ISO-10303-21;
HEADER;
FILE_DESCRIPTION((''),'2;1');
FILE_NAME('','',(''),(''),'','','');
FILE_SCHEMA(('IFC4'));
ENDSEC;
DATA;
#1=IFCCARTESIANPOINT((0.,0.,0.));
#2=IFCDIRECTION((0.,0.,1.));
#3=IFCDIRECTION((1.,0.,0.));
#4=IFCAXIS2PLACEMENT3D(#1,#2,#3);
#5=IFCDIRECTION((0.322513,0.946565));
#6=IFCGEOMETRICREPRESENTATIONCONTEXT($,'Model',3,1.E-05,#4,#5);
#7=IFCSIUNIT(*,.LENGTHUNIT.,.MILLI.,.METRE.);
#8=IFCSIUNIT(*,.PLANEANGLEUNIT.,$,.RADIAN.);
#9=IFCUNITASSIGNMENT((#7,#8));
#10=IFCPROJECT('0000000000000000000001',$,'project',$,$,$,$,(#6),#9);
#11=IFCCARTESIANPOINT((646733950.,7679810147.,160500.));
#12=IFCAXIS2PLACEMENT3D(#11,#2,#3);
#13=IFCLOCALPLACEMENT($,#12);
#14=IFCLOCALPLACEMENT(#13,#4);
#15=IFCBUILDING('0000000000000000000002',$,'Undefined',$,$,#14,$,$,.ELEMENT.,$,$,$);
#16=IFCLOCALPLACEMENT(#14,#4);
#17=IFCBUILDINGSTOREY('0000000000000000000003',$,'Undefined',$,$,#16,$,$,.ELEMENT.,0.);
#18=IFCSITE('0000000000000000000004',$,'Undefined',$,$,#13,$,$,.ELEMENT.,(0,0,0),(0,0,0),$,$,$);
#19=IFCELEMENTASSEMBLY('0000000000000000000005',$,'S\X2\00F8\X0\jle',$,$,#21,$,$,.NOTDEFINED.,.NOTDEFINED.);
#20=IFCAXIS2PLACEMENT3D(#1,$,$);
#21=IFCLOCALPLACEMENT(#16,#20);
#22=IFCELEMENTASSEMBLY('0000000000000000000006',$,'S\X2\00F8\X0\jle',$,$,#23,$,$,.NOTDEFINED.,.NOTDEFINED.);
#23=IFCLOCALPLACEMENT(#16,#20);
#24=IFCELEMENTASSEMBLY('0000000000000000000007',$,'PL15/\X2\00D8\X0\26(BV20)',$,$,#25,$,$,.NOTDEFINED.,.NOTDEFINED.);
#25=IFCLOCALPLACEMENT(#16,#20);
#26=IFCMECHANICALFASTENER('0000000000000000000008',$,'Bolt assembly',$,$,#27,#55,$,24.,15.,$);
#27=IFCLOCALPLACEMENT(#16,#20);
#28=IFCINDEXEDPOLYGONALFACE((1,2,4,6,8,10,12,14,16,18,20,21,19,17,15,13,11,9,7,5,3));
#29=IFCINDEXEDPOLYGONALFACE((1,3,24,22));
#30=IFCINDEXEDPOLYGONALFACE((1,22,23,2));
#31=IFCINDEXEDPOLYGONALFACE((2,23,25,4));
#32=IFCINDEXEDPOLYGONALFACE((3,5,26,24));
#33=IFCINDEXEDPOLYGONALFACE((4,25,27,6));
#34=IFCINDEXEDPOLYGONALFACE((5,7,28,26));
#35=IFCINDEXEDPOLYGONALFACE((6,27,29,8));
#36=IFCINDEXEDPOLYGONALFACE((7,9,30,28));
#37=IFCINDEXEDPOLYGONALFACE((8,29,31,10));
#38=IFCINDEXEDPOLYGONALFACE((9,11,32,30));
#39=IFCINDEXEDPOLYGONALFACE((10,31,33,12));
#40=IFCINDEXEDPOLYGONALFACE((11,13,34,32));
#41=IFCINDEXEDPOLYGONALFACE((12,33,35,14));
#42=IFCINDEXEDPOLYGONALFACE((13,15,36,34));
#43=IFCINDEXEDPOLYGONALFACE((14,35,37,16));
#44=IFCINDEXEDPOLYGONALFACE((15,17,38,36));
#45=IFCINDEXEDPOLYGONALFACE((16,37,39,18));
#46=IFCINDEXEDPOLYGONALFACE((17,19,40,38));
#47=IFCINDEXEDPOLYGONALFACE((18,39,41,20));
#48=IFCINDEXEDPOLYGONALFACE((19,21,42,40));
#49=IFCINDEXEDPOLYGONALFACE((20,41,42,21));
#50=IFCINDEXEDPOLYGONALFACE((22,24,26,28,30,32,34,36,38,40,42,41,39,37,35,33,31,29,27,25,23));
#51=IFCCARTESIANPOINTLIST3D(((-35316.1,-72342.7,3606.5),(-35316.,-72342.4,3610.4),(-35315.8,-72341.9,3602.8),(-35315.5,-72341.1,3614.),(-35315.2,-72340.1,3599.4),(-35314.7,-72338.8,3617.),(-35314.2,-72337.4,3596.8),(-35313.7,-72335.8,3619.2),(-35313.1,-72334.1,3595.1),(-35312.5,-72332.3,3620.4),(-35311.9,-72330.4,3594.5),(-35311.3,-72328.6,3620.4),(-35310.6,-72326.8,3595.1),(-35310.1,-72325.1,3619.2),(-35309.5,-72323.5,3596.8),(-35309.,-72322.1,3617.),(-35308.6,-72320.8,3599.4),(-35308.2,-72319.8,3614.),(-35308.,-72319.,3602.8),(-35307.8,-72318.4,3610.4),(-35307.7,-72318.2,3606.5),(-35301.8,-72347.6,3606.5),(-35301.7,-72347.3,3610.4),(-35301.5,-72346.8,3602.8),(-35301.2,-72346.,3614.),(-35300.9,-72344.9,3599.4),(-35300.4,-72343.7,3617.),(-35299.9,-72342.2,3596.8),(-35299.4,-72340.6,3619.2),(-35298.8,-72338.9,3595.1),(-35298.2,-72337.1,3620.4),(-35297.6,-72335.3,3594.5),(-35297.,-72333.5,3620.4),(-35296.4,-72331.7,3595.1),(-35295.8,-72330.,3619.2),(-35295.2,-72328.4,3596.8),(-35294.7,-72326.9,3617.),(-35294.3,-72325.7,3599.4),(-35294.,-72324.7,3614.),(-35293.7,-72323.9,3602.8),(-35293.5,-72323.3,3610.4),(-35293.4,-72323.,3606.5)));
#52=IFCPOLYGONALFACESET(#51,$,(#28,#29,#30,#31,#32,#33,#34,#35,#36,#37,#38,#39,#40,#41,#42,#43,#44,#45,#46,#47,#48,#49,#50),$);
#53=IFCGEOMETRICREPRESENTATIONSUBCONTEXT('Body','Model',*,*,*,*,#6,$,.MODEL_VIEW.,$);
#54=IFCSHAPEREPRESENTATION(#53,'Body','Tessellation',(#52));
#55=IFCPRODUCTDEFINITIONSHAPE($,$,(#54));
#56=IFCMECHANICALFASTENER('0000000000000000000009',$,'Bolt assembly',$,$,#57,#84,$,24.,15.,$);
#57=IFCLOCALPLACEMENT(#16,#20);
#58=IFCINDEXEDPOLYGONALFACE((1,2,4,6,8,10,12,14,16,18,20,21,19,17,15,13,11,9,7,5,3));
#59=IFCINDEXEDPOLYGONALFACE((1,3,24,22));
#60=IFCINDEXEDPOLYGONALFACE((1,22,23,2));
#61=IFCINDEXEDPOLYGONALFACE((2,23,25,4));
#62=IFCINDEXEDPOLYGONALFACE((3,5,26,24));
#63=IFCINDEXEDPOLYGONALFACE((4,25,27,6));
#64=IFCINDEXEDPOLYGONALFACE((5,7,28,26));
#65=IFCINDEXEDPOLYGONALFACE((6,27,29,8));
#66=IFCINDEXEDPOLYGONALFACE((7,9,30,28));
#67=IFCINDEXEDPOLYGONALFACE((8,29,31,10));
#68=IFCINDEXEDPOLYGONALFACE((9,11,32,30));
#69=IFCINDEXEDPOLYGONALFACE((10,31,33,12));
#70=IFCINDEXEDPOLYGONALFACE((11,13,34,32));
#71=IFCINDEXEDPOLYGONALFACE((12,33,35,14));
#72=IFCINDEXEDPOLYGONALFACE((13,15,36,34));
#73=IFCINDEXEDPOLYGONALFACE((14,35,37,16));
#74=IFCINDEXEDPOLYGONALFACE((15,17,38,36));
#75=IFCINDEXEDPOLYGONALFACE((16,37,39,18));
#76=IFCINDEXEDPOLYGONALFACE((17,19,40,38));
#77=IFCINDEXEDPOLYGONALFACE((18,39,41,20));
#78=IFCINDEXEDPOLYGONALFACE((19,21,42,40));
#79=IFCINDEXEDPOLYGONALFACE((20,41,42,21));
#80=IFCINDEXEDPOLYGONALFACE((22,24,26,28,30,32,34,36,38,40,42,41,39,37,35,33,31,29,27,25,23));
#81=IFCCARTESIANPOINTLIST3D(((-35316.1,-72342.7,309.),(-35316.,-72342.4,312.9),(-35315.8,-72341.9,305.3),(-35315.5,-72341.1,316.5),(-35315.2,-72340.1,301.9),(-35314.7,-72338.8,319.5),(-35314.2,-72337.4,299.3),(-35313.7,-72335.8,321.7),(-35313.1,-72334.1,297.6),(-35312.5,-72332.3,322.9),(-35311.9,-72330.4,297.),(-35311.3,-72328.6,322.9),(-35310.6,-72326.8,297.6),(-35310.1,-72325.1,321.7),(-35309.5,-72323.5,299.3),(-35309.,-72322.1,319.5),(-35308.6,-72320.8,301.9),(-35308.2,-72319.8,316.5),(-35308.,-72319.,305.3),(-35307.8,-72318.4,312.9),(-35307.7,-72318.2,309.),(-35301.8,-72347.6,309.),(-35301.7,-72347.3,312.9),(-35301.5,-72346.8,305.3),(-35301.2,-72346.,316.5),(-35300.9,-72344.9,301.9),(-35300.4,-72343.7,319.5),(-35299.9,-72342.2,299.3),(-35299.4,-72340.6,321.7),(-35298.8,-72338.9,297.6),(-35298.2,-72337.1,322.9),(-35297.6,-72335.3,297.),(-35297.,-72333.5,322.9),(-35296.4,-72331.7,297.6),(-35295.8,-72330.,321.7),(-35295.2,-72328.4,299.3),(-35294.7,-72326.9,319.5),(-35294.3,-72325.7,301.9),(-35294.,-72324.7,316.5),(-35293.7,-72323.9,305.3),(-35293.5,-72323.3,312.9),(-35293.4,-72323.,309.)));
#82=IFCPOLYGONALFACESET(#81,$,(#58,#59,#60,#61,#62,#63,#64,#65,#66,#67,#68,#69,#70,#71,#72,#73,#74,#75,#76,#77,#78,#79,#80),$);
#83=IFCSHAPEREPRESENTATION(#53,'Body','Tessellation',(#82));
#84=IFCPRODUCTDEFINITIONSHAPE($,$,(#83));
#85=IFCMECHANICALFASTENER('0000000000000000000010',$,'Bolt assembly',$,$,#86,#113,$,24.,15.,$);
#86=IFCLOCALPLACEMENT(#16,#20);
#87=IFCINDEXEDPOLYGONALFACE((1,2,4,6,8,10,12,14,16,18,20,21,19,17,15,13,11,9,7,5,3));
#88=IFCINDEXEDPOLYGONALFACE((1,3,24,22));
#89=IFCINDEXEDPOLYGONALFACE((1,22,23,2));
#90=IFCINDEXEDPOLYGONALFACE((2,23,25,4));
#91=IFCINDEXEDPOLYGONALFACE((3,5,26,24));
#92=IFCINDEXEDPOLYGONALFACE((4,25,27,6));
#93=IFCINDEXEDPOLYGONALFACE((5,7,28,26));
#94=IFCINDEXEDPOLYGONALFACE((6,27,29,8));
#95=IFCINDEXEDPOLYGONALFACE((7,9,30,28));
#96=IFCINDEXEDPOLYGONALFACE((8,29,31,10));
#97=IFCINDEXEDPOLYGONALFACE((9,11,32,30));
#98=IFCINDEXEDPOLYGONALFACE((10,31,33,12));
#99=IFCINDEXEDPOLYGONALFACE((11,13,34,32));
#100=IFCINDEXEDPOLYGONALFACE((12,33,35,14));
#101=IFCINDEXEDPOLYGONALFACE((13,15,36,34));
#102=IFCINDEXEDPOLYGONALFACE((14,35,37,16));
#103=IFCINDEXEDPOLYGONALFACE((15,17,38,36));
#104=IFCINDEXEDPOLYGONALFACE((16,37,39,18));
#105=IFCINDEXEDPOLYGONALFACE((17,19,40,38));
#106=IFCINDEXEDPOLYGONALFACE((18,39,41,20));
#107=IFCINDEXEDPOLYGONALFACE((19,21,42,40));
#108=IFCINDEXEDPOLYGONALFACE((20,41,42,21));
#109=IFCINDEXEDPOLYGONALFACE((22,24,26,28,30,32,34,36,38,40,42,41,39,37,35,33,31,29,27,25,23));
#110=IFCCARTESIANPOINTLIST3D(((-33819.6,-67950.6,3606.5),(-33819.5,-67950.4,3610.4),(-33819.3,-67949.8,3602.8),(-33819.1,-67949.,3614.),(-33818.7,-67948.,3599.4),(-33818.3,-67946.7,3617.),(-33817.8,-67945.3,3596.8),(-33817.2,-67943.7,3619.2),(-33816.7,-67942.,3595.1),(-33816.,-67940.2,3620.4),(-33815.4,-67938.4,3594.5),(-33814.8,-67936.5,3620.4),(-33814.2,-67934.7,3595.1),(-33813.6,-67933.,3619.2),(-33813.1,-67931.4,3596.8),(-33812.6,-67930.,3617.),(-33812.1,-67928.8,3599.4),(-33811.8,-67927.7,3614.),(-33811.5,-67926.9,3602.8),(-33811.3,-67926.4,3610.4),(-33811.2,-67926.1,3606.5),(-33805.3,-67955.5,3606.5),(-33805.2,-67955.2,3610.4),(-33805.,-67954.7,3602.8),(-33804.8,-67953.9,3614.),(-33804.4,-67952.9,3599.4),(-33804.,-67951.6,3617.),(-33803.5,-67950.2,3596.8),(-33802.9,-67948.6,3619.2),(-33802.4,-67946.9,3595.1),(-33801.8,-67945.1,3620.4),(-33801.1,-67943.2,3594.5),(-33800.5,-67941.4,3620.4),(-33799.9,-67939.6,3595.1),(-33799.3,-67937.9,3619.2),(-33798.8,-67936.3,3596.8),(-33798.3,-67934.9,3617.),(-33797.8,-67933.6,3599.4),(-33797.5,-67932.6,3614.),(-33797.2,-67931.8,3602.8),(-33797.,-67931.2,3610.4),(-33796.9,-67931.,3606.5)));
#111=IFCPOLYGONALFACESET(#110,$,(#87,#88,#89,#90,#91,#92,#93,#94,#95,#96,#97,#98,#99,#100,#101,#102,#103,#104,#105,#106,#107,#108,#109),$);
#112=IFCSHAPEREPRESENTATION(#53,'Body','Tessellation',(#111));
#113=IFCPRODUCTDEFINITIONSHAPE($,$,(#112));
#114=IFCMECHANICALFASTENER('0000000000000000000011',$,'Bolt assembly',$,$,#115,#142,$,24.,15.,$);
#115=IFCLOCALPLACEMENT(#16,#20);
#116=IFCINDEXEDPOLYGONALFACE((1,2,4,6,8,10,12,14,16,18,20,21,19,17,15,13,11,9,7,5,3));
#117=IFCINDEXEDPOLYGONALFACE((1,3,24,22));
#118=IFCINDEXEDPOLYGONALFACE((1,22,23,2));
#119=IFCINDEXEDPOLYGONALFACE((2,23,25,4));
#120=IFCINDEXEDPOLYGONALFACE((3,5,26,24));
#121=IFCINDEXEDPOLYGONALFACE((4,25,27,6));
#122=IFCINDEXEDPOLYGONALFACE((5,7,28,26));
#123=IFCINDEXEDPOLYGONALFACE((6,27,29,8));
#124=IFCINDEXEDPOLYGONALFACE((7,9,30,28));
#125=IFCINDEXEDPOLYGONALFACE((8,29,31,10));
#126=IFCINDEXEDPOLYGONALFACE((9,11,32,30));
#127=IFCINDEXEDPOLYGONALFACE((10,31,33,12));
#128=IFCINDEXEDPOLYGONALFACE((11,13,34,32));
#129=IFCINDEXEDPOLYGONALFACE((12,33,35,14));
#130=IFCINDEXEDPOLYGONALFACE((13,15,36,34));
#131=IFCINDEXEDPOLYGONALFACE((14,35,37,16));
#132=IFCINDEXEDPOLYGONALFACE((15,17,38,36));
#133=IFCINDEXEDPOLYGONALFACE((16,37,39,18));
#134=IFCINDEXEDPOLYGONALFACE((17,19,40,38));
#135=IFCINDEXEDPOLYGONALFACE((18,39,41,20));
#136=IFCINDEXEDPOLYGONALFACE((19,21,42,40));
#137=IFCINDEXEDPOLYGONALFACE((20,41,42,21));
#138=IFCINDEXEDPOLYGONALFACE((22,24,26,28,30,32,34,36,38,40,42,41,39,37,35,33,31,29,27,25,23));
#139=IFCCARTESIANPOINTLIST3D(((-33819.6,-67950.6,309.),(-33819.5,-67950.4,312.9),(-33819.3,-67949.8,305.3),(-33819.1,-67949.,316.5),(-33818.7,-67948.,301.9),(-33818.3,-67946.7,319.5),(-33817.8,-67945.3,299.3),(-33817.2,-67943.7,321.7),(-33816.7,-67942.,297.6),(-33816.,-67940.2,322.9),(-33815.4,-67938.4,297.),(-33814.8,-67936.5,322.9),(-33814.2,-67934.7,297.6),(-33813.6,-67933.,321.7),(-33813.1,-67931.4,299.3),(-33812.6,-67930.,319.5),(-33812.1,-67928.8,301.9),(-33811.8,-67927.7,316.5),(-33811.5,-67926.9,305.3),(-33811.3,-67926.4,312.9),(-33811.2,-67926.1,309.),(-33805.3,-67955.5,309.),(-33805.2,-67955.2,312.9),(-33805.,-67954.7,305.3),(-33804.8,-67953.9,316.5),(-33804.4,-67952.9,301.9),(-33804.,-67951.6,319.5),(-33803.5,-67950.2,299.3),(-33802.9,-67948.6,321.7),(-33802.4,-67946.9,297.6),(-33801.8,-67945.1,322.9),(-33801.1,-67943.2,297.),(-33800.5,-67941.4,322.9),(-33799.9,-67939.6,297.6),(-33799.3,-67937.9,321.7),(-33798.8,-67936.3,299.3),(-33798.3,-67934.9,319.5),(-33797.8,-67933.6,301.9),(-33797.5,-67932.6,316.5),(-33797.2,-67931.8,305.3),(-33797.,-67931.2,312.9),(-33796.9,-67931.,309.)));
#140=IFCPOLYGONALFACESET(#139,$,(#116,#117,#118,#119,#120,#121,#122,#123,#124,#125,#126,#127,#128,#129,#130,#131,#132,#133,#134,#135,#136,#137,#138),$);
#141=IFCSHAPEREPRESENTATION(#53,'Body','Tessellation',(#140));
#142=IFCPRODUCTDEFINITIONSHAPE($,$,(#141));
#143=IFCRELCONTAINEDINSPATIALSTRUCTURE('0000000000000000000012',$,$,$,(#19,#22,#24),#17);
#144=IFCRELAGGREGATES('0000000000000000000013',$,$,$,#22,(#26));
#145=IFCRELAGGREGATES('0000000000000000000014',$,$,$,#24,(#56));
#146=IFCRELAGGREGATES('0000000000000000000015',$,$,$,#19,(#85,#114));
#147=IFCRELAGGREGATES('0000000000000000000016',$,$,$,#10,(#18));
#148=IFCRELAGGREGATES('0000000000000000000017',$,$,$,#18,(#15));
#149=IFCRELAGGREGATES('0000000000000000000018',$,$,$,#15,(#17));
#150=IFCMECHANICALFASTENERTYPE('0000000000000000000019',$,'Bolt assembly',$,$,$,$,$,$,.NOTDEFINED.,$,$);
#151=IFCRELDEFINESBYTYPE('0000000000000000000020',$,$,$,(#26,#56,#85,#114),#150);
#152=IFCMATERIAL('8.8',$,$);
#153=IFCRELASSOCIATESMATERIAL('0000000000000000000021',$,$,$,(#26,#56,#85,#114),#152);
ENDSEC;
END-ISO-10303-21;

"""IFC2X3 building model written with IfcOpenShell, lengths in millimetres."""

from ifc_helpers import new_model, si_unit, direction, frame, origin_with_axes, origin_2d_with_axis, place, context, subcontext, project, spatial, circle, extrude, source, transform, mapped, material, type_object, element, aggregate, save


model = new_model("IFC2X3")

# Units and contexts
model_context = context("Model", 3, precision=1e-05, world=origin_with_axes(), true_north=direction((0.322513, 0.946565)))
body_context = subcontext(model_context, "Body", "Model", "MODEL_VIEW")
ifc_project = project(units=[si_unit("LENGTHUNIT", "METRE", prefix="MILLI"), si_unit("PLANEANGLEUNIT", "RADIAN")], contexts=[model_context])

# Site, building, storey
site_placement = place(None, frame((646733950.0, 7679810147.0, 160500.0), z_axis=(0.0, 0.0, 1.0), x_axis=(1.0, 0.0, 0.0)))
site = spatial("IfcSite", under=ifc_project, at=site_placement, Name="Undefined", CompositionType="ELEMENT", RefLatitude=(0, 0, 0), RefLongitude=(0, 0, 0))
building_placement = place(site_placement, origin_with_axes())
building = spatial("IfcBuilding", under=site, at=building_placement, Name="Undefined", CompositionType="ELEMENT")
storey_placement = place(building_placement, origin_with_axes())
storey = spatial("IfcBuildingStorey", under=building, at=storey_placement, Name="Undefined", CompositionType="ELEMENT", Elevation=0.0)

# Element assembly
assembly_1_placement = place(storey_placement, origin_with_axes())
assembly_1 = element("IfcElementAssembly", 1, at=assembly_1_placement, inside=storey, Name="Søjle", AssemblyPlace="NOTDEFINED", PredefinedType="NOTDEFINED")

# Element assembly
assembly_2_placement = place(storey_placement, origin_with_axes())
assembly_2 = element("IfcElementAssembly", 2, at=assembly_2_placement, inside=storey, Name="Søjle", AssemblyPlace="NOTDEFINED", PredefinedType="NOTDEFINED")

# Element assembly
assembly_3_placement = place(storey_placement, origin_with_axes())
assembly_3 = element("IfcElementAssembly", 3, at=assembly_3_placement, inside=storey, Name="PL15/Ø26(BV20)", AssemblyPlace="NOTDEFINED", PredefinedType="NOTDEFINED")

# Mechanical fasteners
ifc_material_1 = material(Name="8.8")
mechanical_fastener_type = type_object("IfcMechanicalFastenerType", Name="Bolt assembly")
shared_shape_1 = source(origin_with_axes(), body_context, "Body", "SweptSolid", [
    extrude(circle(Radius=13.0, at=origin_2d_with_axis()), frame((0.0, -7.5, 0.0), z_axis=(0.0, 1.0, 0.0), x_axis=(1.0, 0.0, 0.0)), (0.0, 0.0, 1.0), 15.1),
])
mechanical_fastener_1_placement = place(assembly_2_placement, frame((-35304.8, -72332.9, 3607.5), z_axis=(-0.322513, -0.946565, 0.0), x_axis=(0.0, 0.0, -1.0)))
mechanical_fastener_1 = element("IfcMechanicalFastener", 4, at=mechanical_fastener_1_placement, type_object=mechanical_fastener_type, material=ifc_material_1, Name="Bolt assembly", NominalDiameter=24.0, NominalLength=15.0, context=body_context, shape_type="MappedRepresentation", body=[
    mapped(shared_shape_1, transform((0.0, 0.0, 0.0))),
])
aggregate(assembly_2, [mechanical_fastener_1])
mechanical_fastener_2_placement = place(assembly_3_placement, frame((-35304.8, -72332.9, 310.0), z_axis=(-0.322513, -0.946565, 0.0), x_axis=(0.0, 0.0, -1.0)))
mechanical_fastener_2 = element("IfcMechanicalFastener", 5, at=mechanical_fastener_2_placement, type_object=mechanical_fastener_type, material=ifc_material_1, Name="Bolt assembly", NominalDiameter=24.0, NominalLength=15.0, context=body_context, shape_type="MappedRepresentation", body=[
    mapped(shared_shape_1, transform((0.0, 0.0, 0.0))),
])
aggregate(assembly_3, [mechanical_fastener_2])
mechanical_fastener_3_placement = place(assembly_1_placement, frame((-33808.3, -67940.8, 3607.5), z_axis=(-0.322513, -0.946565, 0.0), x_axis=(0.0, 0.0, -1.0)))
mechanical_fastener_3 = element("IfcMechanicalFastener", 6, at=mechanical_fastener_3_placement, type_object=mechanical_fastener_type, material=ifc_material_1, Name="Bolt assembly", NominalDiameter=24.0, NominalLength=15.0, context=body_context, shape_type="MappedRepresentation", body=[
    mapped(shared_shape_1, transform((0.0, 0.0, 0.0))),
])
mechanical_fastener_4_placement = place(assembly_1_placement, frame((-33808.3, -67940.8, 310.0), z_axis=(-0.322513, -0.946565, 0.0), x_axis=(0.0, 0.0, -1.0)))
mechanical_fastener_4 = element("IfcMechanicalFastener", 7, at=mechanical_fastener_4_placement, type_object=mechanical_fastener_type, material=ifc_material_1, Name="Bolt assembly", NominalDiameter=24.0, NominalLength=15.0, context=body_context, shape_type="MappedRepresentation", body=[
    mapped(shared_shape_1, transform((0.0, 0.0, 0.0))),
])
aggregate(assembly_1, [mechanical_fastener_3, mechanical_fastener_4])

save(model, "model.ifc")
